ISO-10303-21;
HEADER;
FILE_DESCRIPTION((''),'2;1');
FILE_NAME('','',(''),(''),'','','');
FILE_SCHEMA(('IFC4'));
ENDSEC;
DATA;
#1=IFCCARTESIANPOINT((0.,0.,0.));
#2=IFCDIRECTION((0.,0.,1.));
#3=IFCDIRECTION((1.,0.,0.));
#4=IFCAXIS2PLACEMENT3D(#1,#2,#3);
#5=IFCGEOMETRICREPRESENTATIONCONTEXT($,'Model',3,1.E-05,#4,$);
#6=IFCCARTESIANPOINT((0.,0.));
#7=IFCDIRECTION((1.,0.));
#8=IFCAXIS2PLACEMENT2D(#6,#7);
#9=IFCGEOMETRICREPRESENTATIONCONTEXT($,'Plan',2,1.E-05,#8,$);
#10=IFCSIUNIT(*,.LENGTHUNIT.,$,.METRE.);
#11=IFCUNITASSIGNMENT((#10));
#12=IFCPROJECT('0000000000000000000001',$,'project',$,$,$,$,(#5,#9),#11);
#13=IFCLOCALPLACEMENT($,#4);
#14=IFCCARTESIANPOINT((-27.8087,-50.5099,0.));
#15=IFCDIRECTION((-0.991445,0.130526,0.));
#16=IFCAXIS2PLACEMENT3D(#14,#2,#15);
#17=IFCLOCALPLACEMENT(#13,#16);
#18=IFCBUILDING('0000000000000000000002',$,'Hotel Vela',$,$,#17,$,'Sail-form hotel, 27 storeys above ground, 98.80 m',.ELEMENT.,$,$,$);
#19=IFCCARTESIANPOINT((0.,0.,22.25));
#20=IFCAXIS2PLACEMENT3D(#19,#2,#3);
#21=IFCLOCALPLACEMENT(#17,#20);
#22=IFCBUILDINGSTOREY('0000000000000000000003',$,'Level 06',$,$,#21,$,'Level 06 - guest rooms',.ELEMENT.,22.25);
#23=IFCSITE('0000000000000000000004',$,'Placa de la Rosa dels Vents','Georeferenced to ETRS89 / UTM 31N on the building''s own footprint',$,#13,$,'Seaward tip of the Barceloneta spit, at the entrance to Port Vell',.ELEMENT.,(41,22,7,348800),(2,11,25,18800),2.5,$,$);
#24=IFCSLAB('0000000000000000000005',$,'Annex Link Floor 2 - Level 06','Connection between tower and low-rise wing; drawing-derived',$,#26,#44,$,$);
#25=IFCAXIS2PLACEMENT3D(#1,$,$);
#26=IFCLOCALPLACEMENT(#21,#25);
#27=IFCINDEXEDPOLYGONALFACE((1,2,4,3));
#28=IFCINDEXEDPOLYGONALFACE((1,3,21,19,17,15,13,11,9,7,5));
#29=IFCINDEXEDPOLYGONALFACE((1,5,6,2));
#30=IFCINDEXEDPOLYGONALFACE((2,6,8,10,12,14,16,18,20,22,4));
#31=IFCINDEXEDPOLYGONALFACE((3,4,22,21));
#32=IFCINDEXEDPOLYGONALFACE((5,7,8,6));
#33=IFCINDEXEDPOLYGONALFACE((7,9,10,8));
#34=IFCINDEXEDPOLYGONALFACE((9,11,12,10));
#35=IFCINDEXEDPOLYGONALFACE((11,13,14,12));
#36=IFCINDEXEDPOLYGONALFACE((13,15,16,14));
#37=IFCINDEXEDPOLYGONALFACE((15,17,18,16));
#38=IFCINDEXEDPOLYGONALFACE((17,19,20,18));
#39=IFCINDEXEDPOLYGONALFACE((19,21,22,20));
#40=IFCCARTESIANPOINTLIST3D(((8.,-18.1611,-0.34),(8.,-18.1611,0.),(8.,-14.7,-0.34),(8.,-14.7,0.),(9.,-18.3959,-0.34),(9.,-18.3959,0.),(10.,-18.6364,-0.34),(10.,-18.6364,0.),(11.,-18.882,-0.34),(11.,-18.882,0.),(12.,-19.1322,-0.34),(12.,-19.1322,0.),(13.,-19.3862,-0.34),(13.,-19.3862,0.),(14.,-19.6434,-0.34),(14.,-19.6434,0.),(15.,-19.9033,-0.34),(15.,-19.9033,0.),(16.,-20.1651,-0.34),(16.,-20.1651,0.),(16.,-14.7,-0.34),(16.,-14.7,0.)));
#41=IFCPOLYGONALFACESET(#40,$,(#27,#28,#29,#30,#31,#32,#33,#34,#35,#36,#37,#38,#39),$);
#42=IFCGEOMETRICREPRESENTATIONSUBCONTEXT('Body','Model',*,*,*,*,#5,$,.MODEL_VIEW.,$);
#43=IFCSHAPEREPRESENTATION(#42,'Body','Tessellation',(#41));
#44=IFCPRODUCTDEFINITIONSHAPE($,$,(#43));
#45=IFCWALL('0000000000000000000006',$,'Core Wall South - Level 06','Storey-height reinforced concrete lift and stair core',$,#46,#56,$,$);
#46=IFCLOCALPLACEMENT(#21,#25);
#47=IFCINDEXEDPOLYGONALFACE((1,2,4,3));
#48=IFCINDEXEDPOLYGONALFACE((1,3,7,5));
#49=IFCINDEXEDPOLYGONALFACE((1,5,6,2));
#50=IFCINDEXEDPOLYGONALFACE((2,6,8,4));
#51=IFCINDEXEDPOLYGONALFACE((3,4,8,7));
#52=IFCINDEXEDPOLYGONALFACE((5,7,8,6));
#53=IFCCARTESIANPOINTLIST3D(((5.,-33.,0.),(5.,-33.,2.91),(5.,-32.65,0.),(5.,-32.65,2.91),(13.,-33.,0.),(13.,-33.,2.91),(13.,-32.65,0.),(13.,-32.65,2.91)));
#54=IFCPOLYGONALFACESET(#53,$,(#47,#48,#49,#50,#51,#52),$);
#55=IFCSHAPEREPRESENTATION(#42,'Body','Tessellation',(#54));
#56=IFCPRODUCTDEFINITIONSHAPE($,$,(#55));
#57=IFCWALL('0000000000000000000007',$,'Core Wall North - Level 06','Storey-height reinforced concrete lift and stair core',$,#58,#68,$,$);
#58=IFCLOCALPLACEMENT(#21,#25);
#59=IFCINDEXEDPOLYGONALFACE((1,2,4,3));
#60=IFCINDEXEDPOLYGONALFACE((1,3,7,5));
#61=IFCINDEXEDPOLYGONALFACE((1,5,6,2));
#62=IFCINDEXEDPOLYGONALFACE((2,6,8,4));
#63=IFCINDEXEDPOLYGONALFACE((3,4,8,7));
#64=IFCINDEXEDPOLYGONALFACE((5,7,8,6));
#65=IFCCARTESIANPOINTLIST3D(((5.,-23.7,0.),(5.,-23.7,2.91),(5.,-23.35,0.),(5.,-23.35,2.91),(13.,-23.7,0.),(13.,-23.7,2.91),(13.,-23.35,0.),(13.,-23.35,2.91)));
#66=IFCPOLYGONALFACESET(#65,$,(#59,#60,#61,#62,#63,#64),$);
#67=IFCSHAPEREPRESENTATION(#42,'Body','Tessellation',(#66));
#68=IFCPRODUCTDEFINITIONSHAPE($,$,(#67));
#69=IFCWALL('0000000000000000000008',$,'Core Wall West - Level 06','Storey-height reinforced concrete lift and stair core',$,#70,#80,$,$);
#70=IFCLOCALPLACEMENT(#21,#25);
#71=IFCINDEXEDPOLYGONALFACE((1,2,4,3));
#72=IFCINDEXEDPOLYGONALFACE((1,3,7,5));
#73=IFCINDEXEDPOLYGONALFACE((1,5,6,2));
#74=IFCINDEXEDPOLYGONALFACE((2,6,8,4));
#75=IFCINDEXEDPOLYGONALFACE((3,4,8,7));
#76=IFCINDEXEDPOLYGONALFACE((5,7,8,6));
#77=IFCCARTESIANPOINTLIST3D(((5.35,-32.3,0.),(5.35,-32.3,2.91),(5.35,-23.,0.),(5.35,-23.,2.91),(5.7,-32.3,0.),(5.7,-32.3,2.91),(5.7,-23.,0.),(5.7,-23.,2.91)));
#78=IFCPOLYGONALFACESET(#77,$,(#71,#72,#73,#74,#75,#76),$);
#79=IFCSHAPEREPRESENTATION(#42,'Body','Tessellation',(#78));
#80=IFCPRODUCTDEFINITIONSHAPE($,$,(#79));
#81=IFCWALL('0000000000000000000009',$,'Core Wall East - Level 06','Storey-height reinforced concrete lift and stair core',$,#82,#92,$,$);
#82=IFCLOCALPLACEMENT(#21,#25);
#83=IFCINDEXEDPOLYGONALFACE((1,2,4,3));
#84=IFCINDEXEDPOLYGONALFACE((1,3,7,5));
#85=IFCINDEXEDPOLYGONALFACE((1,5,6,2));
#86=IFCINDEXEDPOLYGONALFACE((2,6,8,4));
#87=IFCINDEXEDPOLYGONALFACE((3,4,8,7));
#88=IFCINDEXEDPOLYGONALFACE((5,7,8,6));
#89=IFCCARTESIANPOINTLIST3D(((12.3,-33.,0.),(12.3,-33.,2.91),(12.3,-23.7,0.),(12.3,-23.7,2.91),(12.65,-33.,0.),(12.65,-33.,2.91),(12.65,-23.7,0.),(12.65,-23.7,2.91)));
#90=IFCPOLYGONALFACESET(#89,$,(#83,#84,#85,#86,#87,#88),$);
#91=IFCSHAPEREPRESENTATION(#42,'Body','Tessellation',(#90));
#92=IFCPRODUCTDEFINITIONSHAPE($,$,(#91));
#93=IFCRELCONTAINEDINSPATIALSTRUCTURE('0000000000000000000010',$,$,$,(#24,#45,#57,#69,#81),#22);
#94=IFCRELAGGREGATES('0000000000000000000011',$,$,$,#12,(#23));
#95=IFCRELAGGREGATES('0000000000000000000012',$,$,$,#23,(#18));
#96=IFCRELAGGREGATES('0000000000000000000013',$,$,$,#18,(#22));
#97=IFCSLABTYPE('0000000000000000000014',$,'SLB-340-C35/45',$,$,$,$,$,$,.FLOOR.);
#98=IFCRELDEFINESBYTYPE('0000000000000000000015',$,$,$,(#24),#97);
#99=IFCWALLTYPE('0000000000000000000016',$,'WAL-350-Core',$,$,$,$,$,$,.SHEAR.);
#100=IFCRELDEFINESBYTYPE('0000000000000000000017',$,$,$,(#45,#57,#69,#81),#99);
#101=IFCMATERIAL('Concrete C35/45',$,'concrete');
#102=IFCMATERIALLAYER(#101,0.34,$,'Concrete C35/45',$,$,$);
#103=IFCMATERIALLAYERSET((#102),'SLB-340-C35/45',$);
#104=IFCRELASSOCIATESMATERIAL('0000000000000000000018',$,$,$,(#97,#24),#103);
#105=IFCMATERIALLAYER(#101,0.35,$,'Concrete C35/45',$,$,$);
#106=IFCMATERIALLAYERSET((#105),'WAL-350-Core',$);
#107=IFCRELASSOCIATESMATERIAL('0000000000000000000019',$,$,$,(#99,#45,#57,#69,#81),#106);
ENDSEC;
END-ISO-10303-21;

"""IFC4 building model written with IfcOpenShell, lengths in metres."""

from ifc_helpers import new_model, si_unit, frame, origin_with_axes, origin_2d_with_axis, place, context, subcontext, project, spatial, line, indexed_curve, outline, extrude, material, layer, layer_set, layer_usage, type_object, element, save


model = new_model("IFC4")

# Units and contexts
model_context = context("Model", 3, precision=1e-05, world=origin_with_axes())
plan_context = context("Plan", 2, precision=1e-05, world=origin_2d_with_axis())
body_context = subcontext(model_context, "Body", "Model", "MODEL_VIEW")
ifc_project = project(units=[si_unit("LENGTHUNIT", "METRE")], contexts=[model_context, plan_context])

# Site, building, storey
site_placement = place(None, origin_with_axes())
site = spatial("IfcSite", under=ifc_project, at=site_placement, Name="Placa de la Rosa dels Vents", Description="Georeferenced to ETRS89 / UTM 31N on the building's own footprint", LongName="Seaward tip of the Barceloneta spit, at the entrance to Port Vell", CompositionType="ELEMENT", RefLatitude=(41, 22, 7, 348800), RefLongitude=(2, 11, 25, 18800), RefElevation=2.5)
building_placement = place(site_placement, frame((-27.8087, -50.5099, 0.0), z_axis=(0.0, 0.0, 1.0), x_axis=(-0.991445, 0.130526, 0.0)))
building = spatial("IfcBuilding", under=site, at=building_placement, Name="Hotel Vela", LongName="Sail-form hotel, 27 storeys above ground, 98.80 m", CompositionType="ELEMENT")
storey_placement = place(building_placement, frame((0.0, 0.0, 22.25), z_axis=(0.0, 0.0, 1.0), x_axis=(1.0, 0.0, 0.0)))
storey = spatial("IfcBuildingStorey", under=building, at=storey_placement, Name="Level 06", LongName="Level 06 - guest rooms", CompositionType="ELEMENT", Elevation=22.25)

# Shared definitions
ifc_material = material(Name="Concrete C35/45", Category="concrete")

# Shared definitions
ifc_layer_1 = layer(ifc_material, 0.34, Name="Concrete C35/45")
ifc_layer_set_1 = layer_set([ifc_layer_1], Name="SLB-340-C35/45")
slab_type = type_object("IfcSlabType", Name="SLB-340-C35/45", PredefinedType="FLOOR", material=ifc_layer_set_1)

# Slab
ifc_layer_usage_1 = layer_usage(ifc_layer_set_1, "AXIS3", "POSITIVE", 0.0)
slab_1_placement = place(storey_placement, frame((0.0, 0.0, -0.34), z_axis=(0.0, 0.0, 1.0), x_axis=(1.0, 0.0, 0.0)))
element("IfcSlab", 1, at=slab_1_placement, inside=storey, type_object=slab_type, material=ifc_layer_usage_1, Name="Annex Link Floor 2 - Level 06", Description="Connection between tower and low-rise wing; drawing-derived", context=body_context, shape_type="SweptSolid", body=[
    extrude(outline(indexed_curve([(8.0, -18.1611), (9.0, -18.3959), (10.0, -18.6364), (11.0, -18.882), (12.0, -19.1322), (13.0, -19.3862), (14.0, -19.6434), (15.0, -19.9033), (16.0, -20.1651), (16.0, -14.7), (8.0, -14.7)], segments=[line(1, 2, 3, 4, 5, 6, 7, 8, 9, 10, 11, 1)])), origin_with_axes(), (0.0, 0.0, 1.0), 0.34),
])

# Walls
ifc_layer_2 = layer(ifc_material, 0.35, Name="Concrete C35/45")
ifc_layer_set_2 = layer_set([ifc_layer_2], Name="WAL-350-Core")
ifc_layer_usage_2 = layer_usage(ifc_layer_set_2, "AXIS2", "POSITIVE", 0.0)
wall_type = type_object("IfcWallType", Name="WAL-350-Core", PredefinedType="SHEAR", material=ifc_layer_set_2)
wall_1_placement = place(storey_placement, frame((5.0, -33.0, 0.0), z_axis=(0.0, 0.0, 1.0), x_axis=(1.0, 0.0, 0.0)))
element("IfcWall", 2, at=wall_1_placement, inside=storey, type_object=wall_type, material=ifc_layer_usage_2, Name="Core Wall South - Level 06", Description="Storey-height reinforced concrete lift and stair core", context=body_context, shape_type="SweptSolid", body=[
    extrude(outline(indexed_curve([(0.0, 0.0), (8.0, 0.0), (8.0, 0.35), (0.0, 0.35)], segments=[line(1, 2, 3, 4, 1)])), origin_with_axes(), (0.0, 0.0, 1.0), 2.91),
])
ifc_layer_usage_3 = layer_usage(ifc_layer_set_2, "AXIS2", "POSITIVE", 0.0)
wall_2_placement = place(storey_placement, frame((13.0, -23.35, 0.0), z_axis=(0.0, 0.0, 1.0), x_axis=(-1.0, 0.0, 0.0)))
element("IfcWall", 3, at=wall_2_placement, inside=storey, type_object=wall_type, material=ifc_layer_usage_3, Name="Core Wall North - Level 06", Description="Storey-height reinforced concrete lift and stair core", context=body_context, shape_type="SweptSolid", body=[
    extrude(outline(indexed_curve([(0.0, 0.0), (8.0, 0.0), (8.0, 0.35), (0.0, 0.35)], segments=[line(1, 2, 3, 4, 1)])), origin_with_axes(), (0.0, 0.0, 1.0), 2.91),
])
ifc_layer_usage_4 = layer_usage(ifc_layer_set_2, "AXIS2", "POSITIVE", 0.0)
wall_3_placement = place(storey_placement, frame((5.35, -23.0, 0.0), z_axis=(0.0, 0.0, 1.0), x_axis=(0.0, -1.0, 0.0)))
element("IfcWall", 4, at=wall_3_placement, inside=storey, type_object=wall_type, material=ifc_layer_usage_4, Name="Core Wall West - Level 06", Description="Storey-height reinforced concrete lift and stair core", context=body_context, shape_type="SweptSolid", body=[
    extrude(outline(indexed_curve([(0.0, 0.0), (9.3, 0.0), (9.3, 0.35), (0.0, 0.35)], segments=[line(1, 2, 3, 4, 1)])), origin_with_axes(), (0.0, 0.0, 1.0), 2.91),
])
ifc_layer_usage_5 = layer_usage(ifc_layer_set_2, "AXIS2", "POSITIVE", 0.0)
wall_4_placement = place(storey_placement, frame((12.65, -33.0, 0.0), z_axis=(0.0, 0.0, 1.0), x_axis=(0.0, 1.0, 0.0)))
element("IfcWall", 5, at=wall_4_placement, inside=storey, type_object=wall_type, material=ifc_layer_usage_5, Name="Core Wall East - Level 06", Description="Storey-height reinforced concrete lift and stair core", context=body_context, shape_type="SweptSolid", body=[
    extrude(outline(indexed_curve([(0.0, 0.0), (9.3, 0.0), (9.3, 0.35), (0.0, 0.35)], segments=[line(1, 2, 3, 4, 1)])), origin_with_axes(), (0.0, 0.0, 1.0), 2.91),
])

save(model, "model.ifc")
